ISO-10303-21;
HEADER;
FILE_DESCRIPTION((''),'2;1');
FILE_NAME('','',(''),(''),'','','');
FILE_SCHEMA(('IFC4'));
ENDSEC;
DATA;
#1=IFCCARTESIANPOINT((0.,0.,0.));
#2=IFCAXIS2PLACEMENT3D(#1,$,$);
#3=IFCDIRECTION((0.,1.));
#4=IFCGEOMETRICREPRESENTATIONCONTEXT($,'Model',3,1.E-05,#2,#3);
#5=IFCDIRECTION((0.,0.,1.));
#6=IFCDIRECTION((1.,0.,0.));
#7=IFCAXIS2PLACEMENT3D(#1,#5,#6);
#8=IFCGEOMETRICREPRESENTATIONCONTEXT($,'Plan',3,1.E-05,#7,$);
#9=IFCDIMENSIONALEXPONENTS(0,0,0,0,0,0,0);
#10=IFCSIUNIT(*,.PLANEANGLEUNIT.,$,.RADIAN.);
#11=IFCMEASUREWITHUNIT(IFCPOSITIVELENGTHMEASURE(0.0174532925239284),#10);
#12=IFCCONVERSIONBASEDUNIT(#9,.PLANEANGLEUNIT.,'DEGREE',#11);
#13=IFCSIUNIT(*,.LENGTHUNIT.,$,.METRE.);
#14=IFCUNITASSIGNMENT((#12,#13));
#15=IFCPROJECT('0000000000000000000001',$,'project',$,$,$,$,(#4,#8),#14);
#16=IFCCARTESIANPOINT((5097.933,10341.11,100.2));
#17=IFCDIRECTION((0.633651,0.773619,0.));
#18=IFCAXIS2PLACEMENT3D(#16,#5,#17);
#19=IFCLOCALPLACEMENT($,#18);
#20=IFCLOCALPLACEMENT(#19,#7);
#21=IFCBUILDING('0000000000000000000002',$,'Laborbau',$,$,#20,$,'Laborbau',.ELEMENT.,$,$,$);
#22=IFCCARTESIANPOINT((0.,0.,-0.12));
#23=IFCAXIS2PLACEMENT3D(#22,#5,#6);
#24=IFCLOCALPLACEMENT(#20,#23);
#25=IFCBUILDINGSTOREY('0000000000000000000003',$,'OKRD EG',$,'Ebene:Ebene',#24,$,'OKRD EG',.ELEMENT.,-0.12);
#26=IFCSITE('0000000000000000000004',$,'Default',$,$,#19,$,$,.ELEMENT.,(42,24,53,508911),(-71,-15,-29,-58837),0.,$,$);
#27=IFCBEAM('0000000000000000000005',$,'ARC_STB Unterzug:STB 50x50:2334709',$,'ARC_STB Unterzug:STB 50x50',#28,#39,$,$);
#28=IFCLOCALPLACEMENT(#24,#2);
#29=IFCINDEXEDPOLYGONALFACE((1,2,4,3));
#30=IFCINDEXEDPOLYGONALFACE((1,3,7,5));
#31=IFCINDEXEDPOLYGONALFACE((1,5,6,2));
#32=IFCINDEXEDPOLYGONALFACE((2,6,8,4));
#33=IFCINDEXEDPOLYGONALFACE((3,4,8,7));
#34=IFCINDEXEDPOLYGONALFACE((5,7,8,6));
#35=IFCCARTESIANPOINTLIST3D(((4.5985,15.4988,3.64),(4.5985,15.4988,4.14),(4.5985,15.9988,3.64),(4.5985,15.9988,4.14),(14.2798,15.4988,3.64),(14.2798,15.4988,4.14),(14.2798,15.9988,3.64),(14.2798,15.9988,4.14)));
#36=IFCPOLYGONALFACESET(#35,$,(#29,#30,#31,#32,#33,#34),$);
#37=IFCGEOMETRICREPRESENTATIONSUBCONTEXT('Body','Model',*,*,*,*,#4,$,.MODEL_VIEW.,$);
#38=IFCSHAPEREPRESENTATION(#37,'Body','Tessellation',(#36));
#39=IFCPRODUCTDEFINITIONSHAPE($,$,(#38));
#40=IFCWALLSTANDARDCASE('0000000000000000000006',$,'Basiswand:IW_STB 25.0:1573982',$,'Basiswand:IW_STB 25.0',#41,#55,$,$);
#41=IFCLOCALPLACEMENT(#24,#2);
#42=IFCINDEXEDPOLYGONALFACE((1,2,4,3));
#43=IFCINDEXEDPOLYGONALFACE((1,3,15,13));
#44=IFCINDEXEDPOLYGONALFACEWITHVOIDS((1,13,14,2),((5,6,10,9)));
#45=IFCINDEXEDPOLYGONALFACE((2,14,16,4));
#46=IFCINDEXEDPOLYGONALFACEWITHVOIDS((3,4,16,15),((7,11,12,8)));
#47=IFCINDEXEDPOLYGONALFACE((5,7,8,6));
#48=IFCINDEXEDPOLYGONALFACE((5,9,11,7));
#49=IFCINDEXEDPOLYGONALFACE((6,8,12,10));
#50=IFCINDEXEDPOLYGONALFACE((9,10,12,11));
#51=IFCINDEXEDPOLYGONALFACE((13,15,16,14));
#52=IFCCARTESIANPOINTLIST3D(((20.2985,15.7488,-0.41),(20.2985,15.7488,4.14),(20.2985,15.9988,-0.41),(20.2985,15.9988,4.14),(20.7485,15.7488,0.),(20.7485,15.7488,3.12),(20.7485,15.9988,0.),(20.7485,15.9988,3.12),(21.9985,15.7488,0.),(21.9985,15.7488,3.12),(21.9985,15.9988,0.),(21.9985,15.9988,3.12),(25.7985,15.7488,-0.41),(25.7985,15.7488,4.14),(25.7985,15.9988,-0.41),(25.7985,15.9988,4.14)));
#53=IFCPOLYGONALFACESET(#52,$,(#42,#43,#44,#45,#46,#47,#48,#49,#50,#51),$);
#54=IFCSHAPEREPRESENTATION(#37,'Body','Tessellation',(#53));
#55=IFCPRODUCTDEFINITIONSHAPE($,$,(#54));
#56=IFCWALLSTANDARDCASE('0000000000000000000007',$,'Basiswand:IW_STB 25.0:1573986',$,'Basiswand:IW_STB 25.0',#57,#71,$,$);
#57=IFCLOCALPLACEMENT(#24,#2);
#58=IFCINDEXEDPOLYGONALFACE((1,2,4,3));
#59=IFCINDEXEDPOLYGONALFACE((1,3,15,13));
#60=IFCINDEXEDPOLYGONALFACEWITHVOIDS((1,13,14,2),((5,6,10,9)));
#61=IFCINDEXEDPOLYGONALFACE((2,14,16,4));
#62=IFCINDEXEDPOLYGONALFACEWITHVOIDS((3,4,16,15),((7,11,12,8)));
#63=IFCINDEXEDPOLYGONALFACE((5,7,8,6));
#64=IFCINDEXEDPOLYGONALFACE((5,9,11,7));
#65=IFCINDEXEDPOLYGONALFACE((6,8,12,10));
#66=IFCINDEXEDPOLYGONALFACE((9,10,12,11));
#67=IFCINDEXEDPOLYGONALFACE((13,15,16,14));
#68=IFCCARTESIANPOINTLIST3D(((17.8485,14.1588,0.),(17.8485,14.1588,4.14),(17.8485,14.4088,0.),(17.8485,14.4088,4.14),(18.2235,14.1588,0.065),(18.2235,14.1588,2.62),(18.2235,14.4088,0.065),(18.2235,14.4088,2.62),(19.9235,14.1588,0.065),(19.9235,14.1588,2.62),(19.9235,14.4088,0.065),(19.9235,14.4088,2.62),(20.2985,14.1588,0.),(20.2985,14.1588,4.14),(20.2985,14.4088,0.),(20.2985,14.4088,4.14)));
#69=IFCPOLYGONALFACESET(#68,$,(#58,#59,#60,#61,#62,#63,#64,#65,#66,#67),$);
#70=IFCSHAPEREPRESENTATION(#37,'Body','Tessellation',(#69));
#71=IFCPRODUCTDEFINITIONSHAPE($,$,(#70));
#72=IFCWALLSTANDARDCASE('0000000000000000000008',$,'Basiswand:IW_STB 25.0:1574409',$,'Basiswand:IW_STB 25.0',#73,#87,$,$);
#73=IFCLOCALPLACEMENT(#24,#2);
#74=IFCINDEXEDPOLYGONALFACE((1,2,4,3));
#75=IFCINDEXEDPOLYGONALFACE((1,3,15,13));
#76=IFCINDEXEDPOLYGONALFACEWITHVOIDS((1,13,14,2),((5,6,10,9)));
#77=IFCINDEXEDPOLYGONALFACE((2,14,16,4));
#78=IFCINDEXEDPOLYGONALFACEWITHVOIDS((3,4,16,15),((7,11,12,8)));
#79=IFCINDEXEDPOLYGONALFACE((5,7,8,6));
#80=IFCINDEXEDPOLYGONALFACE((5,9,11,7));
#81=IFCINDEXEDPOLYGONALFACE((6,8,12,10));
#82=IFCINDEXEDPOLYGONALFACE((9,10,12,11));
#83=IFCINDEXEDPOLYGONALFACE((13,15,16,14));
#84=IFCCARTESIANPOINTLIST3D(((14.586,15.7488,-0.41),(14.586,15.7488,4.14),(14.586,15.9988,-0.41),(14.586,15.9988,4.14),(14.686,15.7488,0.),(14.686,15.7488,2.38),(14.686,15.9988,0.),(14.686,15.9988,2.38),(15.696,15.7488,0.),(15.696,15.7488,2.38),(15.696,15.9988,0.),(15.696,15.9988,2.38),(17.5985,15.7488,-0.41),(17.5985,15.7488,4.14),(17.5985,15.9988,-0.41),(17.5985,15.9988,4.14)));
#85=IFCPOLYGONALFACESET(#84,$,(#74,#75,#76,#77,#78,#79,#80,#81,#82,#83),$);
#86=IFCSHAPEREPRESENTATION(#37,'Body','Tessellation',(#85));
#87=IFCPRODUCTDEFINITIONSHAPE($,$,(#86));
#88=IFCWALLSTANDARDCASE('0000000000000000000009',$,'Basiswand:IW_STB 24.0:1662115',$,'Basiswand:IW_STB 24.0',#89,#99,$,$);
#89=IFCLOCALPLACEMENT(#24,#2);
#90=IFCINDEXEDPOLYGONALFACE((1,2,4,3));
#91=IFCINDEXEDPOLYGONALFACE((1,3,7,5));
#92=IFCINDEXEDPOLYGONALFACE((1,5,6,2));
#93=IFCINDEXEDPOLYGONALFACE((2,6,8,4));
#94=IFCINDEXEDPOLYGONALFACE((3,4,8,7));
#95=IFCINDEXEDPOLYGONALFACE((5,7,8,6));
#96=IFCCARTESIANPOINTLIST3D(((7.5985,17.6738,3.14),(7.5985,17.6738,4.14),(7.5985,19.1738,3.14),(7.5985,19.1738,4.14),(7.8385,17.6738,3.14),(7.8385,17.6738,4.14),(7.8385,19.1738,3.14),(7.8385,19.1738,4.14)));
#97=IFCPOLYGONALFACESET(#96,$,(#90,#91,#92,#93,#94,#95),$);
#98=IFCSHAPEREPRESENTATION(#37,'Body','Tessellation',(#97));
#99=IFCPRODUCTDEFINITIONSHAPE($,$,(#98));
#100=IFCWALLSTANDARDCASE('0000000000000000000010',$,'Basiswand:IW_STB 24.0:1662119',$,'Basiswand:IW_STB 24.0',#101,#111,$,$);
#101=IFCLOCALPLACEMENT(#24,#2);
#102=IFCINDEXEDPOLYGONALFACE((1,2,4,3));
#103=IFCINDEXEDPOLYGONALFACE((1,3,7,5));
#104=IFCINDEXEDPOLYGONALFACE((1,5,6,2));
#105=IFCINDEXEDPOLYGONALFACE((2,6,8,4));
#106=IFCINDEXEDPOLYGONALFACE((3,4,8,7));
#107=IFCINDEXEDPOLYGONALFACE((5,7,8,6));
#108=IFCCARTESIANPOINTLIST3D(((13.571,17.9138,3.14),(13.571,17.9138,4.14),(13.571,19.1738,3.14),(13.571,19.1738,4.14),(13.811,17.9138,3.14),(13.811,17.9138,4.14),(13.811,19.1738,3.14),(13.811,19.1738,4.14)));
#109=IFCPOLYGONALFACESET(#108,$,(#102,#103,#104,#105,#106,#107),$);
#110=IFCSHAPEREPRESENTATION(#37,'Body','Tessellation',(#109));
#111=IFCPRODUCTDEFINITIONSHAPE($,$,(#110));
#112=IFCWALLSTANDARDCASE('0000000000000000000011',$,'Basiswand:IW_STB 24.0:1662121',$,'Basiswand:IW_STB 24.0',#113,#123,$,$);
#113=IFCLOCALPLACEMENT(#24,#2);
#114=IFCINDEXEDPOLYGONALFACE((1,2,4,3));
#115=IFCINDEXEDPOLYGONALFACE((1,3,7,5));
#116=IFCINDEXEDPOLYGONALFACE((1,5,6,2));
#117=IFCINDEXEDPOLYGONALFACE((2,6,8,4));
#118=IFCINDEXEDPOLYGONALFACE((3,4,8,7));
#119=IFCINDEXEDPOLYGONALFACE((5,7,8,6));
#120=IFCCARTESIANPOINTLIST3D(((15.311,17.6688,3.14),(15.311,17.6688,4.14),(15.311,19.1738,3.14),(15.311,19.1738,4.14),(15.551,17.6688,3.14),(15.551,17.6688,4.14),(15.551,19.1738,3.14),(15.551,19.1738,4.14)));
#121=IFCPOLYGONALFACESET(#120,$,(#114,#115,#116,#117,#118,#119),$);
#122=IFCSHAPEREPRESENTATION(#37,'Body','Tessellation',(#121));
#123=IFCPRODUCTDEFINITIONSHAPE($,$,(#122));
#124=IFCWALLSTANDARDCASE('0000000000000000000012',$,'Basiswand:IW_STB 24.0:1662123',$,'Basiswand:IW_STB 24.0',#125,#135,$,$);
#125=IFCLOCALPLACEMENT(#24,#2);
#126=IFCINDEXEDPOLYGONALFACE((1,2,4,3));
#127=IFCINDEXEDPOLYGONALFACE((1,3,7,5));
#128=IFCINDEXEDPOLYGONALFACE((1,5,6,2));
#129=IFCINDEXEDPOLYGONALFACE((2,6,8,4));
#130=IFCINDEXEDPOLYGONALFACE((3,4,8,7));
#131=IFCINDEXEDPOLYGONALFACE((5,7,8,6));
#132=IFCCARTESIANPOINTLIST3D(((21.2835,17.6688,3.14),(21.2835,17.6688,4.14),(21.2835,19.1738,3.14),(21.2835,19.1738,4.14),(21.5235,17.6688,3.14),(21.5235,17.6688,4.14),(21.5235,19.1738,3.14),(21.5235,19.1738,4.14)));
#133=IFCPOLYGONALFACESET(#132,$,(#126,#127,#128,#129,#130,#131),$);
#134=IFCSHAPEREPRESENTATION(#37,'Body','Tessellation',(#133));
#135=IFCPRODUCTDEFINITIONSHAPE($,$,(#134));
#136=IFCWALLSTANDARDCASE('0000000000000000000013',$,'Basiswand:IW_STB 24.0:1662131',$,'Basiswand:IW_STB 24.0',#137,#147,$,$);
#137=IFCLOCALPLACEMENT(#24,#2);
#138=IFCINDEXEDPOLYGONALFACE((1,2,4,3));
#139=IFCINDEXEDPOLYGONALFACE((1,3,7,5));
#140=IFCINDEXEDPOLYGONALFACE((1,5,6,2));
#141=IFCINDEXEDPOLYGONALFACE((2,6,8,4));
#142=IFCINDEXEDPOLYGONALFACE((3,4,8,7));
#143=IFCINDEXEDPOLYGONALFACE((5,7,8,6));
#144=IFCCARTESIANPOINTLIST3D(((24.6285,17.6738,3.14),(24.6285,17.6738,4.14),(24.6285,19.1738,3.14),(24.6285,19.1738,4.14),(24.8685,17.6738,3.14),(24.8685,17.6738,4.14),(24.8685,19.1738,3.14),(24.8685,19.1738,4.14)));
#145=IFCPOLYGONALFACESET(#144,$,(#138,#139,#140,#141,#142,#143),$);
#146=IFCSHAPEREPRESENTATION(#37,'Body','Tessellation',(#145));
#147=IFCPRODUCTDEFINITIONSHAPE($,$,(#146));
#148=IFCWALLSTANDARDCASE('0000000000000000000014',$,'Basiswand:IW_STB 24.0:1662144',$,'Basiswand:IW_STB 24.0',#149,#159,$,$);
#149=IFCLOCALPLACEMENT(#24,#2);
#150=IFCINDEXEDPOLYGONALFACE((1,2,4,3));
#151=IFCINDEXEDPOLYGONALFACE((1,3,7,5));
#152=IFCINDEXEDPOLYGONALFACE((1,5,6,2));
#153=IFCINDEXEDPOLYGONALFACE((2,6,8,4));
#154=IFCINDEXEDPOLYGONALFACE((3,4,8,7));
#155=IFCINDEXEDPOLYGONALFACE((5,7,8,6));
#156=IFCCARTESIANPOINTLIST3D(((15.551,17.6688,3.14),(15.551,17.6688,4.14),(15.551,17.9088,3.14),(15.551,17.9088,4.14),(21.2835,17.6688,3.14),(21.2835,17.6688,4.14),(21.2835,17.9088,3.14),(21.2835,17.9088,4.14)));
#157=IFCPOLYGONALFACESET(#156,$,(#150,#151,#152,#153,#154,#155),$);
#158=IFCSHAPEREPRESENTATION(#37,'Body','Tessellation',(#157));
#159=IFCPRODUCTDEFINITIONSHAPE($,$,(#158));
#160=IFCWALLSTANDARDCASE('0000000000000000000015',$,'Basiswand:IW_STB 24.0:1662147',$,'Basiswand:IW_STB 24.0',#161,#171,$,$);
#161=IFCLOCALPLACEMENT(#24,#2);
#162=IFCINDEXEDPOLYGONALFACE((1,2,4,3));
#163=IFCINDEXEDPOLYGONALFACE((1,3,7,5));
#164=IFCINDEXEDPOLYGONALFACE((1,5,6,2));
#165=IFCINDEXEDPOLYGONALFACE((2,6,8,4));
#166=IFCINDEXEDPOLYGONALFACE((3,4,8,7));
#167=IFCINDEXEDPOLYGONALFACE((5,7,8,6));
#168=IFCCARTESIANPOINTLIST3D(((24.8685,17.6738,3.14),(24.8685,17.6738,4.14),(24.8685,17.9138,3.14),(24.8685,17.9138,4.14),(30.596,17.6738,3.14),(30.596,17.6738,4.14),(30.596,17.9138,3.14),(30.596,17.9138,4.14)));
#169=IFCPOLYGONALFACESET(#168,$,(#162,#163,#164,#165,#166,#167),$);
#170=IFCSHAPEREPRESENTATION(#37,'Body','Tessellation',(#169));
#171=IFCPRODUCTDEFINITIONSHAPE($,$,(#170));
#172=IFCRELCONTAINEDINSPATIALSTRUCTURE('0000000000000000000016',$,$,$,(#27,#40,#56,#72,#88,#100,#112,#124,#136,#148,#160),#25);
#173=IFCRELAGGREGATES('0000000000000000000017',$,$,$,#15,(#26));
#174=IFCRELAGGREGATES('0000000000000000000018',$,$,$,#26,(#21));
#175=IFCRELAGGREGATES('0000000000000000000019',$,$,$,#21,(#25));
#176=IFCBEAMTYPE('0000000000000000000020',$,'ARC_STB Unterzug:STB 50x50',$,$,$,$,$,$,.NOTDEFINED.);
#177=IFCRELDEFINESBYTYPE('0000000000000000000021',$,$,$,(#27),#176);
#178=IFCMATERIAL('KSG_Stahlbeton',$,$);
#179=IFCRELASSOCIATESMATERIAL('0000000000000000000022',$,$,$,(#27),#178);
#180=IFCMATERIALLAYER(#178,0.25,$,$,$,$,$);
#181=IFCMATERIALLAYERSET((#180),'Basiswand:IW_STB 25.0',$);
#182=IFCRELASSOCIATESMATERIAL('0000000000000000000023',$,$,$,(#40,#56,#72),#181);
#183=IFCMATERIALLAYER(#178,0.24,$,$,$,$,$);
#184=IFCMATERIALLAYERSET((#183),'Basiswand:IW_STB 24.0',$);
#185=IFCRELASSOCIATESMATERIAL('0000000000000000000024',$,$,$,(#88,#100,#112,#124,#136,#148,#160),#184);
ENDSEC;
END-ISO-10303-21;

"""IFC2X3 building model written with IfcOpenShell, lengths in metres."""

from ifc_helpers import new_model, entity, si_unit, converted_unit, direction, frame, frame_2d, origin, origin_with_axes, place, context, subcontext, project, spatial, rectangle, extrude, clip, halfspace, material, layer, layer_set, layer_usage, type_object, element, save


model = new_model("IFC2X3")

# Units and contexts
model_context = context("Model", 3, precision=1e-05, world=origin(), true_north=direction((0.0, 1.0)))
plan_context = context("Plan", 3, precision=1e-05, world=origin_with_axes())
body_context = subcontext(model_context, "Body", "Model", "MODEL_VIEW")
ifc_project = project(units=[converted_unit("PLANEANGLEUNIT", "DEGREE", entity("IfcPositiveLengthMeasure", 0.0174532925239284), si_unit("PLANEANGLEUNIT", "RADIAN"), dimensions=[0, 0, 0, 0, 0, 0, 0]), si_unit("LENGTHUNIT", "METRE")], contexts=[model_context, plan_context])

# Site, building, storey
site_placement = place(None, frame((5097.933, 10341.11, 100.2), z_axis=(0.0, 0.0, 1.0), x_axis=(0.633651, 0.773619, 0.0)))
site = spatial("IfcSite", under=ifc_project, at=site_placement, Name="Default", CompositionType="ELEMENT", RefLatitude=(42, 24, 53, 508911), RefLongitude=(-71, -15, -29, -58837), RefElevation=0.0)
building_placement = place(site_placement, origin_with_axes())
building = spatial("IfcBuilding", under=site, at=building_placement, Name="Laborbau", LongName="Laborbau", CompositionType="ELEMENT")
storey_placement = place(building_placement, frame((0.0, 0.0, -0.12), z_axis=(0.0, 0.0, 1.0), x_axis=(1.0, 0.0, 0.0)))
storey = spatial("IfcBuildingStorey", under=building, at=storey_placement, Name="OKRD EG", ObjectType="Ebene:Ebene", LongName="OKRD EG", CompositionType="ELEMENT", Elevation=-0.12)

# Beam
ifc_material = material(Name="KSG_Stahlbeton")
beam_type = type_object("IfcBeamType", Name="ARC_STB Unterzug:STB 50x50", PredefinedType="NOTDEFINED")
beam_placement = place(storey_placement, frame((14.2798, 15.7488, 4.14), z_axis=(0.0, 0.0, 1.0), x_axis=(-1.0, 0.0, 0.0)))
element("IfcBeam", 1, at=beam_placement, inside=storey, type_object=beam_type, material=ifc_material, Name="ARC_STB Unterzug:STB 50x50:2334709", ObjectType="ARC_STB Unterzug:STB 50x50", context=body_context, shape_type="SweptSolid", body=[
    extrude(rectangle(XDim=0.5, YDim=0.5, at=frame_2d((0.0, 0.0), x_axis=(1.0, 0.0))), frame((0.0, 0.0, -0.25), z_axis=(1.0, 0.0, 0.0), x_axis=(0.0, 0.0, -1.0)), (0.0, 0.0, 1.0), 9.6813),
])

# Wall, openings
ifc_layer_1 = layer(ifc_material, 0.25)
ifc_layer_set_1 = layer_set([ifc_layer_1], Name="Basiswand:IW_STB 25.0")
ifc_layer_usage_1 = layer_usage(ifc_layer_set_1, "AXIS2", "NEGATIVE", 0.125)
wall_1_placement = place(storey_placement, frame((20.2985, 15.8738, -0.41), z_axis=(0.0, 0.0, 1.0), x_axis=(1.0, 0.0, 0.0)))
wall_1 = element("IfcWallStandardCase", 2, at=wall_1_placement, inside=storey, material=ifc_layer_usage_1, Name="Basiswand:IW_STB 25.0:1573982", ObjectType="Basiswand:IW_STB 25.0", context=body_context, shape_type="SweptSolid", body=[
    extrude(rectangle(XDim=5.5, YDim=0.25, at=frame_2d((2.75, 0.0), x_axis=(-1.0, 0.0))), origin(), (0.0, 0.0, 1.0), 4.55),
])
opening_1_placement = place(wall_1_placement, frame((-20.2985, -15.8738, 0.41), z_axis=(0.0, 0.0, 1.0), x_axis=(1.0, 0.0, 0.0)))
element("IfcOpeningElement", 3, at=opening_1_placement, cuts=wall_1, ObjectType="Opening", context=body_context, shape_type="SweptSolid", body=[
    extrude(rectangle(XDim=3.12, YDim=1.25, at=frame_2d((0.0, 0.0), x_axis=(1.0, 0.0))), frame((21.3735, 14.2248, 1.56), z_axis=(0.0, 1.0, 0.0), x_axis=(0.0, 0.0, 1.0)), (0.0, 0.0, 1.0), 3.048),
])
opening_2_placement = place(wall_1_placement, frame((1.7, 0.125, 0.41), z_axis=(0.0, 0.0, 1.0), x_axis=(1.0, 0.0, 0.0)))
element("IfcOpeningElement", 4, at=opening_2_placement, cuts=wall_1, ObjectType="Opening", context=body_context, shape_type="SweptSolid", body=[
    extrude(rectangle(XDim=3.12, YDim=1.25, at=frame_2d((1.56, 0.625), x_axis=(1.0, 0.0))), frame((0.0, 0.0, 0.0), z_axis=(0.0, -1.0, 0.0), x_axis=(0.0, 0.0, 1.0)), (0.0, 0.0, 1.0), 0.25),
])

# Wall, opening
ifc_layer_usage_2 = layer_usage(ifc_layer_set_1, "AXIS2", "NEGATIVE", 0.125)
wall_2_placement = place(storey_placement, frame((17.8485, 14.2838, 0.0), z_axis=(0.0, 0.0, 1.0), x_axis=(1.0, 0.0, 0.0)))
wall_2 = element("IfcWallStandardCase", 5, at=wall_2_placement, inside=storey, material=ifc_layer_usage_2, Name="Basiswand:IW_STB 25.0:1573986", ObjectType="Basiswand:IW_STB 25.0", context=body_context, shape_type="Clipping", body=[
    clip(extrude(rectangle(XDim=2.45, YDim=0.25, at=frame_2d((1.225, 0.0), x_axis=(-1.0, 0.0))), origin(), (0.0, 0.0, 1.0), 4.14), halfspace(frame((0.0, 0.0, -1.58)), True)),
])
opening_3_placement = place(wall_2_placement, origin_with_axes())
element("IfcOpeningElement", 6, at=opening_3_placement, cuts=wall_2, ObjectType="Opening", context=body_context, shape_type="SweptSolid", body=[
    extrude(rectangle(XDim=2.555, YDim=1.7, at=frame_2d((0.0, 0.0), x_axis=(1.0, 0.0))), frame((1.225, -0.125, 1.3425), z_axis=(0.0, 1.0, 0.0), x_axis=(0.0, 0.0, -1.0)), (0.0, 0.0, 1.0), 0.25),
])

# Wall, openings
ifc_layer_usage_3 = layer_usage(ifc_layer_set_1, "AXIS2", "NEGATIVE", 0.125)
wall_3_placement = place(storey_placement, frame((14.586, 15.8738, -0.41), z_axis=(0.0, 0.0, 1.0), x_axis=(1.0, 0.0, 0.0)))
wall_3 = element("IfcWallStandardCase", 7, at=wall_3_placement, inside=storey, material=ifc_layer_usage_3, Name="Basiswand:IW_STB 25.0:1574409", ObjectType="Basiswand:IW_STB 25.0", context=body_context, shape_type="SweptSolid", body=[
    extrude(rectangle(XDim=3.0125, YDim=0.25, at=frame_2d((1.5063, 0.0), x_axis=(-1.0, 0.0))), origin(), (0.0, 0.0, 1.0), 4.55),
])
opening_4_placement = place(wall_3_placement, frame((-14.586, -15.8738, 0.41), z_axis=(0.0, 0.0, 1.0), x_axis=(1.0, 0.0, 0.0)))
element("IfcOpeningElement", 8, at=opening_4_placement, cuts=wall_3, ObjectType="Opening", context=body_context, shape_type="SweptSolid", body=[
    extrude(rectangle(XDim=2.38, YDim=1.01, at=frame_2d((0.0, 0.0), x_axis=(0.0, 1.0))), frame((15.191, 14.4748, 1.19), z_axis=(0.0, 1.0, 0.0), x_axis=(-1.0, 0.0, 0.0)), (0.0, 0.0, 1.0), 3.048),
])
opening_5_placement = place(wall_3_placement, frame((1.11, 0.125, 0.41), z_axis=(0.0, 0.0, 1.0), x_axis=(1.0, 0.0, 0.0)))
element("IfcOpeningElement", 9, at=opening_5_placement, cuts=wall_3, ObjectType="Opening", context=body_context, shape_type="SweptSolid", body=[
    extrude(rectangle(XDim=2.38, YDim=1.01, at=frame_2d((1.19, 0.505), x_axis=(1.0, 0.0))), frame((0.0, 0.0, 0.0), z_axis=(0.0, -1.0, 0.0), x_axis=(0.0, 0.0, 1.0)), (0.0, 0.0, 1.0), 0.25),
])

# Walls
ifc_layer_2 = layer(ifc_material, 0.24)
ifc_layer_set_2 = layer_set([ifc_layer_2], Name="Basiswand:IW_STB 24.0")
ifc_layer_usage_4 = layer_usage(ifc_layer_set_2, "AXIS2", "POSITIVE", -0.12)
wall_4_placement = place(storey_placement, frame((7.7185, 19.1738, 3.14), z_axis=(0.0, 0.0, 1.0), x_axis=(0.0, -1.0, 0.0)))
element("IfcWallStandardCase", 10, at=wall_4_placement, inside=storey, material=ifc_layer_usage_4, Name="Basiswand:IW_STB 24.0:1662115", ObjectType="Basiswand:IW_STB 24.0", context=body_context, shape_type="SweptSolid", body=[
    extrude(rectangle(XDim=1.5, YDim=0.24, at=frame_2d((0.75, 0.0), x_axis=(-1.0, 0.0))), origin(), (0.0, 0.0, 1.0), 1.0),
])
ifc_layer_usage_5 = layer_usage(ifc_layer_set_2, "AXIS2", "POSITIVE", -0.12)
wall_5_placement = place(storey_placement, frame((13.691, 17.9138, 3.14), z_axis=(0.0, 0.0, 1.0), x_axis=(0.0, 1.0, 0.0)))
element("IfcWallStandardCase", 11, at=wall_5_placement, inside=storey, material=ifc_layer_usage_5, Name="Basiswand:IW_STB 24.0:1662119", ObjectType="Basiswand:IW_STB 24.0", context=body_context, shape_type="SweptSolid", body=[
    extrude(rectangle(XDim=1.26, YDim=0.24, at=frame_2d((0.63, 0.0), x_axis=(-1.0, 0.0))), origin(), (0.0, 0.0, 1.0), 1.0),
])
ifc_layer_usage_6 = layer_usage(ifc_layer_set_2, "AXIS2", "POSITIVE", -0.12)
wall_6_placement = place(storey_placement, frame((15.431, 19.1738, 3.14), z_axis=(0.0, 0.0, 1.0), x_axis=(0.0, -1.0, 0.0)))
element("IfcWallStandardCase", 12, at=wall_6_placement, inside=storey, material=ifc_layer_usage_6, Name="Basiswand:IW_STB 24.0:1662121", ObjectType="Basiswand:IW_STB 24.0", context=body_context, shape_type="SweptSolid", body=[
    extrude(rectangle(XDim=1.505, YDim=0.24, at=frame_2d((0.7525, 0.0), x_axis=(-1.0, 0.0))), origin(), (0.0, 0.0, 1.0), 1.0),
])
ifc_layer_usage_7 = layer_usage(ifc_layer_set_2, "AXIS2", "POSITIVE", -0.12)
wall_7_placement = place(storey_placement, frame((21.4035, 17.6688, 3.14), z_axis=(0.0, 0.0, 1.0), x_axis=(0.0, 1.0, 0.0)))
element("IfcWallStandardCase", 13, at=wall_7_placement, inside=storey, material=ifc_layer_usage_7, Name="Basiswand:IW_STB 24.0:1662123", ObjectType="Basiswand:IW_STB 24.0", context=body_context, shape_type="SweptSolid", body=[
    extrude(rectangle(XDim=1.505, YDim=0.24, at=frame_2d((0.7525, 0.0), x_axis=(-1.0, 0.0))), origin(), (0.0, 0.0, 1.0), 1.0),
])
ifc_layer_usage_8 = layer_usage(ifc_layer_set_2, "AXIS2", "NEGATIVE", 0.12)
wall_8_placement = place(storey_placement, frame((24.7485, 17.6738, 3.14), z_axis=(0.0, 0.0, 1.0), x_axis=(0.0, 1.0, 0.0)))
element("IfcWallStandardCase", 14, at=wall_8_placement, inside=storey, material=ifc_layer_usage_8, Name="Basiswand:IW_STB 24.0:1662131", ObjectType="Basiswand:IW_STB 24.0", context=body_context, shape_type="SweptSolid", body=[
    extrude(rectangle(XDim=1.5, YDim=0.24, at=frame_2d((0.75, 0.0), x_axis=(-1.0, 0.0))), origin(), (0.0, 0.0, 1.0), 1.0),
])
ifc_layer_usage_9 = layer_usage(ifc_layer_set_2, "AXIS2", "POSITIVE", -0.12)
wall_9_placement = place(storey_placement, frame((15.551, 17.7888, 3.14), z_axis=(0.0, 0.0, 1.0), x_axis=(1.0, 0.0, 0.0)))
element("IfcWallStandardCase", 15, at=wall_9_placement, inside=storey, material=ifc_layer_usage_9, Name="Basiswand:IW_STB 24.0:1662144", ObjectType="Basiswand:IW_STB 24.0", context=body_context, shape_type="SweptSolid", body=[
    extrude(rectangle(XDim=5.7325, YDim=0.24, at=frame_2d((2.8663, 0.0), x_axis=(-1.0, 0.0))), origin(), (0.0, 0.0, 1.0), 1.0),
])
ifc_layer_usage_10 = layer_usage(ifc_layer_set_2, "AXIS2", "POSITIVE", -0.12)
wall_10_placement = place(storey_placement, frame((24.8685, 17.7938, 3.14), z_axis=(0.0, 0.0, 1.0), x_axis=(1.0, 0.0, 0.0)))
element("IfcWallStandardCase", 16, at=wall_10_placement, inside=storey, material=ifc_layer_usage_10, Name="Basiswand:IW_STB 24.0:1662147", ObjectType="Basiswand:IW_STB 24.0", context=body_context, shape_type="SweptSolid", body=[
    extrude(rectangle(XDim=5.7275, YDim=0.24, at=frame_2d((2.8638, 0.0), x_axis=(-1.0, 0.0))), origin(), (0.0, 0.0, 1.0), 1.0),
])

save(model, "model.ifc")
